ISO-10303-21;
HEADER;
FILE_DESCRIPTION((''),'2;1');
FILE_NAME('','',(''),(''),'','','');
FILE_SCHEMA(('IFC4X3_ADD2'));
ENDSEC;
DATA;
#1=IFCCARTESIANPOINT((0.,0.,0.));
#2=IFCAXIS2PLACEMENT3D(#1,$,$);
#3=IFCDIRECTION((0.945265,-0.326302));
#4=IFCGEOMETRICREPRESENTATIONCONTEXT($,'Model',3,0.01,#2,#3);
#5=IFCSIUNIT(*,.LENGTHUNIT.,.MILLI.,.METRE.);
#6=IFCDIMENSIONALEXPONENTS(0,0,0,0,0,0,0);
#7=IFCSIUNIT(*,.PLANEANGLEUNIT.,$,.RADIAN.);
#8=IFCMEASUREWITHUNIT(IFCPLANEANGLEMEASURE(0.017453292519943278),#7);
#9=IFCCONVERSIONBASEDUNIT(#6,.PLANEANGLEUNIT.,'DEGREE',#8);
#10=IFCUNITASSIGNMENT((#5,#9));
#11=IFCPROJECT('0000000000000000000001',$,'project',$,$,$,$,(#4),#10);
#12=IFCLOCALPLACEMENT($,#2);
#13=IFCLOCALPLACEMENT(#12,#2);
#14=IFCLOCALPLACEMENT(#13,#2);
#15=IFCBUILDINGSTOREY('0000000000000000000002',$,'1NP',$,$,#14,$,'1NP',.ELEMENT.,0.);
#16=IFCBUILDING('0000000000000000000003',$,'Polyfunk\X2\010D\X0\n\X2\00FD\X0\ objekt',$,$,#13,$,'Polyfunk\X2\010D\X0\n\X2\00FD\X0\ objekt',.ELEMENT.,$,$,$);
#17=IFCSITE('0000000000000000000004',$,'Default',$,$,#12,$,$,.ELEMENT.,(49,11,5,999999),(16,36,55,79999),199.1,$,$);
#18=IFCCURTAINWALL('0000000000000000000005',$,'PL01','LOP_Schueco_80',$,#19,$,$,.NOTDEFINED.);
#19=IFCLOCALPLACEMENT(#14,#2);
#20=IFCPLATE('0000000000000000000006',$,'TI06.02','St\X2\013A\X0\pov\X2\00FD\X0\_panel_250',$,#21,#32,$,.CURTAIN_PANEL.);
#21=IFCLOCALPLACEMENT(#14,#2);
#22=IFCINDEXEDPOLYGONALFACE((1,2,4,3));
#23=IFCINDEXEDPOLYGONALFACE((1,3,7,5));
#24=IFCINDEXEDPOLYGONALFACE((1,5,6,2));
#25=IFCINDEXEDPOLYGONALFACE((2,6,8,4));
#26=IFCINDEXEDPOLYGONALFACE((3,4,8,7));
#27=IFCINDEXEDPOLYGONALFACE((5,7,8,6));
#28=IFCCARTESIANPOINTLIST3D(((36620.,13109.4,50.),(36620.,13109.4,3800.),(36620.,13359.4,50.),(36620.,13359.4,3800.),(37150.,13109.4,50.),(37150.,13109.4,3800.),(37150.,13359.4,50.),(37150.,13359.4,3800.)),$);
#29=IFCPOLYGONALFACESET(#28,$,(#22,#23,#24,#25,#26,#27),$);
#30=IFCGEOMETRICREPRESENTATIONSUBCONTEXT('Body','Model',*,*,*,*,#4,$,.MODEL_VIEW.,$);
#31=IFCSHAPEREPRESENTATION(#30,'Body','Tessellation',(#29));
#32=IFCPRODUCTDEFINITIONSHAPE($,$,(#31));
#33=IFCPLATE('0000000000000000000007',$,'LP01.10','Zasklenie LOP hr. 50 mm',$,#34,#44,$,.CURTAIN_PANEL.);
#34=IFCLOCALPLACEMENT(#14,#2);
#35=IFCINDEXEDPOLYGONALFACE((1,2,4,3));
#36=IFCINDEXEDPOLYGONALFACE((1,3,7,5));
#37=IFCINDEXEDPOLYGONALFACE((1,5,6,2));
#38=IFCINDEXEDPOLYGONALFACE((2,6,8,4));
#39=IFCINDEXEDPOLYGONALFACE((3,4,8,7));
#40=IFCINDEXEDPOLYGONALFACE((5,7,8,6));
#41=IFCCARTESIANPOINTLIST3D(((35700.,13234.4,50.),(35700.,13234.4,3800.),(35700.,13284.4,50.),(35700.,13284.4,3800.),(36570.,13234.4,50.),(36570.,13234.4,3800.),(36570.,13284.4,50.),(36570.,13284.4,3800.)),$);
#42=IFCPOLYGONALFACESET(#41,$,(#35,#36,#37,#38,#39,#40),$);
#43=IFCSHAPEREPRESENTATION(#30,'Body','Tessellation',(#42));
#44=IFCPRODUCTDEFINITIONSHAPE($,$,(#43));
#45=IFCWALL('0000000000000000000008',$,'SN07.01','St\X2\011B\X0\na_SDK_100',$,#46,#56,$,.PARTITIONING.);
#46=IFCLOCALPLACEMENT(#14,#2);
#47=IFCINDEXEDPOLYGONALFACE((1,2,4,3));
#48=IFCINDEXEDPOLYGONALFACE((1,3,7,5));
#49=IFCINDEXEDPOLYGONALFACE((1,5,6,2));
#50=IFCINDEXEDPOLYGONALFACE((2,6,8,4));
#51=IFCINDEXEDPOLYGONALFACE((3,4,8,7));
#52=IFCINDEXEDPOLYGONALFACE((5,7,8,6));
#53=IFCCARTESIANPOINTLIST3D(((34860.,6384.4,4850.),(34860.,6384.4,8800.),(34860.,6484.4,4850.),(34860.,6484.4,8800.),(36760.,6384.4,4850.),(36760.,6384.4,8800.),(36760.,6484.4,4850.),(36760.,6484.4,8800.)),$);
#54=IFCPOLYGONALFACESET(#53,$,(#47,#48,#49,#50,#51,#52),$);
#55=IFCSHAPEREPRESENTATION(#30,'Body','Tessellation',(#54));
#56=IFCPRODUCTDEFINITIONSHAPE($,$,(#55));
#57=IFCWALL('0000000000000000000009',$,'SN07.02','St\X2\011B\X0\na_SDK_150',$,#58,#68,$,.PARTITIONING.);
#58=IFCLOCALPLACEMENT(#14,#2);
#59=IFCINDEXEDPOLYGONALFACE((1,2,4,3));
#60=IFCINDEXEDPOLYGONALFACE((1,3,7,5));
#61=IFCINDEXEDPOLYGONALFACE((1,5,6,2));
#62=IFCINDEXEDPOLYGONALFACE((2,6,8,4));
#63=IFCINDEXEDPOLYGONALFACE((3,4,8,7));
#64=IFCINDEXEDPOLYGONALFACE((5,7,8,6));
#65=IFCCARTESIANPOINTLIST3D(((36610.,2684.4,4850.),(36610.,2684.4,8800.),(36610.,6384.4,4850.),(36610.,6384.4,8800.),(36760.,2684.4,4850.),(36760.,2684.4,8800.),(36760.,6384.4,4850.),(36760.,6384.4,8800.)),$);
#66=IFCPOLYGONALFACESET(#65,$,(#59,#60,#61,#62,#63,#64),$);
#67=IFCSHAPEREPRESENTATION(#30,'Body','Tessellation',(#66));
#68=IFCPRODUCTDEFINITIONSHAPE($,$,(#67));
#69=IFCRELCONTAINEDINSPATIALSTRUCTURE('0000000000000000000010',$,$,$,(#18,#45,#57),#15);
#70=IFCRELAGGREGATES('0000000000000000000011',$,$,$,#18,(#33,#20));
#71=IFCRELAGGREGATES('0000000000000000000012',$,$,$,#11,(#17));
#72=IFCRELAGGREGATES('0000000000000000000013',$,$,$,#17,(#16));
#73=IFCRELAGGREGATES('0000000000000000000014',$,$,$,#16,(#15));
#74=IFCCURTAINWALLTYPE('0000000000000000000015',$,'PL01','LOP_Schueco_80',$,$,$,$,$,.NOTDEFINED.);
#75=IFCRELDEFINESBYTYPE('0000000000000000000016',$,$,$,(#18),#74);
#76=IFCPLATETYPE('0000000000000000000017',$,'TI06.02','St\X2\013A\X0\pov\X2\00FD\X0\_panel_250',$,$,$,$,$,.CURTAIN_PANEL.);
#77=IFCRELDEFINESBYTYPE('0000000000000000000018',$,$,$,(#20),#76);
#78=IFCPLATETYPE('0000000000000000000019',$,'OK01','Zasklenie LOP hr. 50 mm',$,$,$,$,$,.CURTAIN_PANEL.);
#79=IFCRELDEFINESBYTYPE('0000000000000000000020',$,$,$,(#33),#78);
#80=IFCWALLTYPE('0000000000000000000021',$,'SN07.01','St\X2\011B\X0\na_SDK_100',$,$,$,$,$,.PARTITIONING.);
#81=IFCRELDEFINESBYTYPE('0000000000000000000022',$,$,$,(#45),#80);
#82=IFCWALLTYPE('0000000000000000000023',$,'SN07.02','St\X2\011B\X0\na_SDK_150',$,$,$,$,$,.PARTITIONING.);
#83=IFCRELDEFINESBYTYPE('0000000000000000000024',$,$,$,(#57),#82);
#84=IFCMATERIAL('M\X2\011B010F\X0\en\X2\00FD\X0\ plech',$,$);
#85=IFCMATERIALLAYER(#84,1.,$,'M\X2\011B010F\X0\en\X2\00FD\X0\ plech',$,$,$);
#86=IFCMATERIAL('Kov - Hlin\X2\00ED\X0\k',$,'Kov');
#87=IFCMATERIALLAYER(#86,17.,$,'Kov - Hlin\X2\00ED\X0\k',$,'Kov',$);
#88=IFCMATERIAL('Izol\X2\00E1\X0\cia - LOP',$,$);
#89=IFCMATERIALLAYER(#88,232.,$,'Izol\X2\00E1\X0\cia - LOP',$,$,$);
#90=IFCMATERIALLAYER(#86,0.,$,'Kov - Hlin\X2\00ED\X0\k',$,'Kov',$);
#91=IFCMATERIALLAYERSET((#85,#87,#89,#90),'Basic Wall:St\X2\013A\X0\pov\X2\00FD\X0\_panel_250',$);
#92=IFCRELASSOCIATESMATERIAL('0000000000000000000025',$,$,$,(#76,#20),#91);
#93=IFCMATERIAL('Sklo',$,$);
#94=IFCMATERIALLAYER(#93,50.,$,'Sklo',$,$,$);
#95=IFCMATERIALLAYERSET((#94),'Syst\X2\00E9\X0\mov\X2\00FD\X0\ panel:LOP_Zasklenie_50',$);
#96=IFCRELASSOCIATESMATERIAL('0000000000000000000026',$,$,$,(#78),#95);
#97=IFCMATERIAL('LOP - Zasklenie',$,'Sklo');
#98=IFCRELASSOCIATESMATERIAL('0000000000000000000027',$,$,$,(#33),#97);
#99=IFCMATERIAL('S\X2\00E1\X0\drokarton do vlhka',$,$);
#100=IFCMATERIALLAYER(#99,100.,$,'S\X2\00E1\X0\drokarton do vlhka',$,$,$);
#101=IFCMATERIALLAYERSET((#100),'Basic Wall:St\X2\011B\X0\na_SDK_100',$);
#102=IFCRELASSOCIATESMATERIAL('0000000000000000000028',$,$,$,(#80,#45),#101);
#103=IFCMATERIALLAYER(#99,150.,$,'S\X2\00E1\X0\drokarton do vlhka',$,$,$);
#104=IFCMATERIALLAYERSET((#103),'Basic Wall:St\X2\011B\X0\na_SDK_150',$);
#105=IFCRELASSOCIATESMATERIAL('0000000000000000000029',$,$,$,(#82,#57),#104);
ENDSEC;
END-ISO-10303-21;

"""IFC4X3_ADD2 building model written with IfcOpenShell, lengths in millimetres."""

from ifc_helpers import new_model, entity, si_unit, converted_unit, direction, frame, frame_2d, origin, place, context, subcontext, project, spatial, polyline, rectangle, extrude, clip, bounded_halfspace, source, transform, mapped, material, layer, layer_set, layer_usage, type_object, type_shapes, element, aggregate, save


model = new_model("IFC4X3_ADD2")

# Units and contexts
model_context = context("Model", 3, precision=0.01, world=origin(), true_north=direction((0.945265, -0.326302)))
body_context = subcontext(model_context, "Body", "Model", "MODEL_VIEW")
ifc_project = project(units=[si_unit("LENGTHUNIT", "METRE", prefix="MILLI"), converted_unit("PLANEANGLEUNIT", "DEGREE", entity("IfcPlaneAngleMeasure", 0.017453292519943278), si_unit("PLANEANGLEUNIT", "RADIAN"), dimensions=[0, 0, 0, 0, 0, 0, 0])], contexts=[model_context])

# Site, building, storey
site_placement = place(None, origin())
site = spatial("IfcSite", under=ifc_project, at=site_placement, Name="Default", CompositionType="ELEMENT", RefLatitude=(49, 11, 5, 999999), RefLongitude=(16, 36, 55, 79999), RefElevation=199.1)
building_placement = place(site_placement, origin())
building = spatial("IfcBuilding", under=site, at=building_placement, Name="Polyfunkčný objekt", LongName="Polyfunkčný objekt", CompositionType="ELEMENT")
storey_placement = place(building_placement, origin())
storey = spatial("IfcBuildingStorey", under=building, at=storey_placement, Name="1NP", LongName="1NP", CompositionType="ELEMENT", Elevation=0.0)

# Curtain wall, plates
curtain_wall_type = type_object("IfcCurtainWallType", Name="PL01", Description="LOP_Schueco_80", PredefinedType="NOTDEFINED")
curtain_wall_placement = place(storey_placement, origin())
curtain_wall = element("IfcCurtainWall", 1, at=curtain_wall_placement, inside=storey, type_object=curtain_wall_type, Name="PL01", Description="LOP_Schueco_80", PredefinedType="NOTDEFINED")
ifc_material_1 = material(Name="Měďený plech")
ifc_layer_1 = layer(ifc_material_1, 1.0, Name="Měďený plech")
ifc_material_2 = material(Name="Kov - Hliník", Category="Kov")
ifc_layer_2 = layer(ifc_material_2, 17.0, Name="Kov - Hliník", Category="Kov")
ifc_material_3 = material(Name="Izolácia - LOP")
ifc_layer_3 = layer(ifc_material_3, 232.0, Name="Izolácia - LOP")
ifc_layer_4 = layer(ifc_material_2, 0.0, Name="Kov - Hliník", Category="Kov")
ifc_layer_set_1 = layer_set([ifc_layer_1, ifc_layer_2, ifc_layer_3, ifc_layer_4], Name="Basic Wall:Stĺpový_panel_250")
ifc_layer_usage_1 = layer_usage(ifc_layer_set_1, "AXIS2", "NEGATIVE", 125.0)
plate_type_1 = type_object("IfcPlateType", Name="TI06.02", Description="Stĺpový_panel_250", PredefinedType="CURTAIN_PANEL", material=ifc_layer_set_1)
plate_1_placement = place(storey_placement, frame((36620.0, 13234.4, 50.0)))
plate_1 = element("IfcPlate", 2, at=plate_1_placement, type_object=plate_type_1, material=ifc_layer_usage_1, Name="TI06.02", Description="Stĺpový_panel_250", PredefinedType="CURTAIN_PANEL", context=body_context, shape_type="SweptSolid", body=[
    extrude(rectangle(XDim=250.0, YDim=530.0, at=frame_2d((0.0, 0.0), x_axis=(1.0, 0.0))), frame((265.0, 0.0, 0.0), z_axis=(0.0, 0.0, 1.0), x_axis=(0.0, 1.0, 0.0)), (0.0, 0.0, 1.0), 3750.0),
])
ifc_material_4 = material(Name="LOP - Zasklenie", Category="Sklo")
ifc_material_5 = material(Name="Sklo")
ifc_layer_5 = layer(ifc_material_5, 50.0, Name="Sklo")
ifc_layer_set_2 = layer_set([ifc_layer_5], Name="Systémový panel:LOP_Zasklenie_50")
plate_type_2 = type_object("IfcPlateType", Name="OK01", Description="Zasklenie LOP hr. 50 mm", PredefinedType="CURTAIN_PANEL", material=ifc_layer_set_2)
shared_shape_1 = source(origin(), body_context, "Body", "SweptSolid", [
    extrude(rectangle(XDim=3750.0, YDim=870.0, at=frame_2d((-141.7, 0.0), x_axis=(1.0, 0.0))), frame((0.0, 0.0, 2016.7), z_axis=(0.0, 1.0, 0.0), x_axis=(0.0, 0.0, 1.0)), (0.0, 0.0, 1.0), 50.0),
])
type_shapes(plate_type_2, [shared_shape_1])
plate_2_placement = place(curtain_wall_placement, frame((36135.0, 13234.4, 50.0)))
plate_2 = element("IfcPlate", 3, at=plate_2_placement, type_object=plate_type_2, material=ifc_material_4, Name="LP01.10", Description="Zasklenie LOP hr. 50 mm", PredefinedType="CURTAIN_PANEL", context=body_context, shape_type="MappedRepresentation", body=[
    mapped(shared_shape_1, transform((0.0, 0.0, 0.0), scale=1.0)),
])
aggregate(curtain_wall, [plate_2, plate_1])

# Walls
ifc_material_6 = material(Name="Sádrokarton do vlhka")
ifc_layer_6 = layer(ifc_material_6, 100.0, Name="Sádrokarton do vlhka")
ifc_layer_set_3 = layer_set([ifc_layer_6], Name="Basic Wall:Stěna_SDK_100")
wall_type_1 = type_object("IfcWallType", Name="SN07.01", Description="Stěna_SDK_100", PredefinedType="PARTITIONING", material=ifc_layer_set_3)
wall_1_placement = place(storey_placement, frame((36760.0, 6434.4, 4850.0), z_axis=(0.0, 0.0, 1.0), x_axis=(-1.0, 0.0, 0.0)))
element("IfcWall", 4, at=wall_1_placement, inside=storey, type_object=wall_type_1, material=ifc_layer_set_3, Name="SN07.01", Description="Stěna_SDK_100", PredefinedType="PARTITIONING", context=body_context, shape_type="Clipping", body=[
    clip(clip(extrude(rectangle(XDim=1900.0, YDim=100.0, at=frame_2d((950.0, 0.0), x_axis=(-1.0, 0.0))), origin(), (0.0, 0.0, 1.0), 3950.0), bounded_halfspace(frame((1900.0, -50.0, 0.0)), True, frame((1900.0, -50.0, 0.0)), polyline([(0.0, 0.0), (0.0, 100.0), (-1750.0, 100.0), (-1900.0, 100.0), (-1900.0, 0.0), (0.0, 0.0)]))), bounded_halfspace(frame((0.0, -50.0, 3950.0), z_axis=(0.0, 0.0, -1.0), x_axis=(-1.0, 0.0, 0.0)), True, frame((0.0, -50.0, 3950.0)), polyline([(0.0, 0.0), (1900.0, 0.0), (1900.0, 100.0), (150.0, 100.0), (0.0, 100.0), (0.0, 0.0)]))),
])
ifc_layer_7 = layer(ifc_material_6, 150.0, Name="Sádrokarton do vlhka")
ifc_layer_set_4 = layer_set([ifc_layer_7], Name="Basic Wall:Stěna_SDK_150")
wall_type_2 = type_object("IfcWallType", Name="SN07.02", Description="Stěna_SDK_150", PredefinedType="PARTITIONING", material=ifc_layer_set_4)
wall_2_placement = place(storey_placement, frame((36685.0, 6384.4, 4850.0), z_axis=(0.0, 0.0, 1.0), x_axis=(0.0, -1.0, 0.0)))
element("IfcWall", 5, at=wall_2_placement, inside=storey, type_object=wall_type_2, material=ifc_layer_set_4, Name="SN07.02", Description="Stěna_SDK_150", PredefinedType="PARTITIONING", context=body_context, shape_type="SweptSolid", body=[
    extrude(rectangle(XDim=3700.0, YDim=150.0, at=frame_2d((1850.0, 0.0), x_axis=(-1.0, 0.0))), origin(), (0.0, 0.0, 1.0), 3950.0),
])

save(model, "model.ifc")
